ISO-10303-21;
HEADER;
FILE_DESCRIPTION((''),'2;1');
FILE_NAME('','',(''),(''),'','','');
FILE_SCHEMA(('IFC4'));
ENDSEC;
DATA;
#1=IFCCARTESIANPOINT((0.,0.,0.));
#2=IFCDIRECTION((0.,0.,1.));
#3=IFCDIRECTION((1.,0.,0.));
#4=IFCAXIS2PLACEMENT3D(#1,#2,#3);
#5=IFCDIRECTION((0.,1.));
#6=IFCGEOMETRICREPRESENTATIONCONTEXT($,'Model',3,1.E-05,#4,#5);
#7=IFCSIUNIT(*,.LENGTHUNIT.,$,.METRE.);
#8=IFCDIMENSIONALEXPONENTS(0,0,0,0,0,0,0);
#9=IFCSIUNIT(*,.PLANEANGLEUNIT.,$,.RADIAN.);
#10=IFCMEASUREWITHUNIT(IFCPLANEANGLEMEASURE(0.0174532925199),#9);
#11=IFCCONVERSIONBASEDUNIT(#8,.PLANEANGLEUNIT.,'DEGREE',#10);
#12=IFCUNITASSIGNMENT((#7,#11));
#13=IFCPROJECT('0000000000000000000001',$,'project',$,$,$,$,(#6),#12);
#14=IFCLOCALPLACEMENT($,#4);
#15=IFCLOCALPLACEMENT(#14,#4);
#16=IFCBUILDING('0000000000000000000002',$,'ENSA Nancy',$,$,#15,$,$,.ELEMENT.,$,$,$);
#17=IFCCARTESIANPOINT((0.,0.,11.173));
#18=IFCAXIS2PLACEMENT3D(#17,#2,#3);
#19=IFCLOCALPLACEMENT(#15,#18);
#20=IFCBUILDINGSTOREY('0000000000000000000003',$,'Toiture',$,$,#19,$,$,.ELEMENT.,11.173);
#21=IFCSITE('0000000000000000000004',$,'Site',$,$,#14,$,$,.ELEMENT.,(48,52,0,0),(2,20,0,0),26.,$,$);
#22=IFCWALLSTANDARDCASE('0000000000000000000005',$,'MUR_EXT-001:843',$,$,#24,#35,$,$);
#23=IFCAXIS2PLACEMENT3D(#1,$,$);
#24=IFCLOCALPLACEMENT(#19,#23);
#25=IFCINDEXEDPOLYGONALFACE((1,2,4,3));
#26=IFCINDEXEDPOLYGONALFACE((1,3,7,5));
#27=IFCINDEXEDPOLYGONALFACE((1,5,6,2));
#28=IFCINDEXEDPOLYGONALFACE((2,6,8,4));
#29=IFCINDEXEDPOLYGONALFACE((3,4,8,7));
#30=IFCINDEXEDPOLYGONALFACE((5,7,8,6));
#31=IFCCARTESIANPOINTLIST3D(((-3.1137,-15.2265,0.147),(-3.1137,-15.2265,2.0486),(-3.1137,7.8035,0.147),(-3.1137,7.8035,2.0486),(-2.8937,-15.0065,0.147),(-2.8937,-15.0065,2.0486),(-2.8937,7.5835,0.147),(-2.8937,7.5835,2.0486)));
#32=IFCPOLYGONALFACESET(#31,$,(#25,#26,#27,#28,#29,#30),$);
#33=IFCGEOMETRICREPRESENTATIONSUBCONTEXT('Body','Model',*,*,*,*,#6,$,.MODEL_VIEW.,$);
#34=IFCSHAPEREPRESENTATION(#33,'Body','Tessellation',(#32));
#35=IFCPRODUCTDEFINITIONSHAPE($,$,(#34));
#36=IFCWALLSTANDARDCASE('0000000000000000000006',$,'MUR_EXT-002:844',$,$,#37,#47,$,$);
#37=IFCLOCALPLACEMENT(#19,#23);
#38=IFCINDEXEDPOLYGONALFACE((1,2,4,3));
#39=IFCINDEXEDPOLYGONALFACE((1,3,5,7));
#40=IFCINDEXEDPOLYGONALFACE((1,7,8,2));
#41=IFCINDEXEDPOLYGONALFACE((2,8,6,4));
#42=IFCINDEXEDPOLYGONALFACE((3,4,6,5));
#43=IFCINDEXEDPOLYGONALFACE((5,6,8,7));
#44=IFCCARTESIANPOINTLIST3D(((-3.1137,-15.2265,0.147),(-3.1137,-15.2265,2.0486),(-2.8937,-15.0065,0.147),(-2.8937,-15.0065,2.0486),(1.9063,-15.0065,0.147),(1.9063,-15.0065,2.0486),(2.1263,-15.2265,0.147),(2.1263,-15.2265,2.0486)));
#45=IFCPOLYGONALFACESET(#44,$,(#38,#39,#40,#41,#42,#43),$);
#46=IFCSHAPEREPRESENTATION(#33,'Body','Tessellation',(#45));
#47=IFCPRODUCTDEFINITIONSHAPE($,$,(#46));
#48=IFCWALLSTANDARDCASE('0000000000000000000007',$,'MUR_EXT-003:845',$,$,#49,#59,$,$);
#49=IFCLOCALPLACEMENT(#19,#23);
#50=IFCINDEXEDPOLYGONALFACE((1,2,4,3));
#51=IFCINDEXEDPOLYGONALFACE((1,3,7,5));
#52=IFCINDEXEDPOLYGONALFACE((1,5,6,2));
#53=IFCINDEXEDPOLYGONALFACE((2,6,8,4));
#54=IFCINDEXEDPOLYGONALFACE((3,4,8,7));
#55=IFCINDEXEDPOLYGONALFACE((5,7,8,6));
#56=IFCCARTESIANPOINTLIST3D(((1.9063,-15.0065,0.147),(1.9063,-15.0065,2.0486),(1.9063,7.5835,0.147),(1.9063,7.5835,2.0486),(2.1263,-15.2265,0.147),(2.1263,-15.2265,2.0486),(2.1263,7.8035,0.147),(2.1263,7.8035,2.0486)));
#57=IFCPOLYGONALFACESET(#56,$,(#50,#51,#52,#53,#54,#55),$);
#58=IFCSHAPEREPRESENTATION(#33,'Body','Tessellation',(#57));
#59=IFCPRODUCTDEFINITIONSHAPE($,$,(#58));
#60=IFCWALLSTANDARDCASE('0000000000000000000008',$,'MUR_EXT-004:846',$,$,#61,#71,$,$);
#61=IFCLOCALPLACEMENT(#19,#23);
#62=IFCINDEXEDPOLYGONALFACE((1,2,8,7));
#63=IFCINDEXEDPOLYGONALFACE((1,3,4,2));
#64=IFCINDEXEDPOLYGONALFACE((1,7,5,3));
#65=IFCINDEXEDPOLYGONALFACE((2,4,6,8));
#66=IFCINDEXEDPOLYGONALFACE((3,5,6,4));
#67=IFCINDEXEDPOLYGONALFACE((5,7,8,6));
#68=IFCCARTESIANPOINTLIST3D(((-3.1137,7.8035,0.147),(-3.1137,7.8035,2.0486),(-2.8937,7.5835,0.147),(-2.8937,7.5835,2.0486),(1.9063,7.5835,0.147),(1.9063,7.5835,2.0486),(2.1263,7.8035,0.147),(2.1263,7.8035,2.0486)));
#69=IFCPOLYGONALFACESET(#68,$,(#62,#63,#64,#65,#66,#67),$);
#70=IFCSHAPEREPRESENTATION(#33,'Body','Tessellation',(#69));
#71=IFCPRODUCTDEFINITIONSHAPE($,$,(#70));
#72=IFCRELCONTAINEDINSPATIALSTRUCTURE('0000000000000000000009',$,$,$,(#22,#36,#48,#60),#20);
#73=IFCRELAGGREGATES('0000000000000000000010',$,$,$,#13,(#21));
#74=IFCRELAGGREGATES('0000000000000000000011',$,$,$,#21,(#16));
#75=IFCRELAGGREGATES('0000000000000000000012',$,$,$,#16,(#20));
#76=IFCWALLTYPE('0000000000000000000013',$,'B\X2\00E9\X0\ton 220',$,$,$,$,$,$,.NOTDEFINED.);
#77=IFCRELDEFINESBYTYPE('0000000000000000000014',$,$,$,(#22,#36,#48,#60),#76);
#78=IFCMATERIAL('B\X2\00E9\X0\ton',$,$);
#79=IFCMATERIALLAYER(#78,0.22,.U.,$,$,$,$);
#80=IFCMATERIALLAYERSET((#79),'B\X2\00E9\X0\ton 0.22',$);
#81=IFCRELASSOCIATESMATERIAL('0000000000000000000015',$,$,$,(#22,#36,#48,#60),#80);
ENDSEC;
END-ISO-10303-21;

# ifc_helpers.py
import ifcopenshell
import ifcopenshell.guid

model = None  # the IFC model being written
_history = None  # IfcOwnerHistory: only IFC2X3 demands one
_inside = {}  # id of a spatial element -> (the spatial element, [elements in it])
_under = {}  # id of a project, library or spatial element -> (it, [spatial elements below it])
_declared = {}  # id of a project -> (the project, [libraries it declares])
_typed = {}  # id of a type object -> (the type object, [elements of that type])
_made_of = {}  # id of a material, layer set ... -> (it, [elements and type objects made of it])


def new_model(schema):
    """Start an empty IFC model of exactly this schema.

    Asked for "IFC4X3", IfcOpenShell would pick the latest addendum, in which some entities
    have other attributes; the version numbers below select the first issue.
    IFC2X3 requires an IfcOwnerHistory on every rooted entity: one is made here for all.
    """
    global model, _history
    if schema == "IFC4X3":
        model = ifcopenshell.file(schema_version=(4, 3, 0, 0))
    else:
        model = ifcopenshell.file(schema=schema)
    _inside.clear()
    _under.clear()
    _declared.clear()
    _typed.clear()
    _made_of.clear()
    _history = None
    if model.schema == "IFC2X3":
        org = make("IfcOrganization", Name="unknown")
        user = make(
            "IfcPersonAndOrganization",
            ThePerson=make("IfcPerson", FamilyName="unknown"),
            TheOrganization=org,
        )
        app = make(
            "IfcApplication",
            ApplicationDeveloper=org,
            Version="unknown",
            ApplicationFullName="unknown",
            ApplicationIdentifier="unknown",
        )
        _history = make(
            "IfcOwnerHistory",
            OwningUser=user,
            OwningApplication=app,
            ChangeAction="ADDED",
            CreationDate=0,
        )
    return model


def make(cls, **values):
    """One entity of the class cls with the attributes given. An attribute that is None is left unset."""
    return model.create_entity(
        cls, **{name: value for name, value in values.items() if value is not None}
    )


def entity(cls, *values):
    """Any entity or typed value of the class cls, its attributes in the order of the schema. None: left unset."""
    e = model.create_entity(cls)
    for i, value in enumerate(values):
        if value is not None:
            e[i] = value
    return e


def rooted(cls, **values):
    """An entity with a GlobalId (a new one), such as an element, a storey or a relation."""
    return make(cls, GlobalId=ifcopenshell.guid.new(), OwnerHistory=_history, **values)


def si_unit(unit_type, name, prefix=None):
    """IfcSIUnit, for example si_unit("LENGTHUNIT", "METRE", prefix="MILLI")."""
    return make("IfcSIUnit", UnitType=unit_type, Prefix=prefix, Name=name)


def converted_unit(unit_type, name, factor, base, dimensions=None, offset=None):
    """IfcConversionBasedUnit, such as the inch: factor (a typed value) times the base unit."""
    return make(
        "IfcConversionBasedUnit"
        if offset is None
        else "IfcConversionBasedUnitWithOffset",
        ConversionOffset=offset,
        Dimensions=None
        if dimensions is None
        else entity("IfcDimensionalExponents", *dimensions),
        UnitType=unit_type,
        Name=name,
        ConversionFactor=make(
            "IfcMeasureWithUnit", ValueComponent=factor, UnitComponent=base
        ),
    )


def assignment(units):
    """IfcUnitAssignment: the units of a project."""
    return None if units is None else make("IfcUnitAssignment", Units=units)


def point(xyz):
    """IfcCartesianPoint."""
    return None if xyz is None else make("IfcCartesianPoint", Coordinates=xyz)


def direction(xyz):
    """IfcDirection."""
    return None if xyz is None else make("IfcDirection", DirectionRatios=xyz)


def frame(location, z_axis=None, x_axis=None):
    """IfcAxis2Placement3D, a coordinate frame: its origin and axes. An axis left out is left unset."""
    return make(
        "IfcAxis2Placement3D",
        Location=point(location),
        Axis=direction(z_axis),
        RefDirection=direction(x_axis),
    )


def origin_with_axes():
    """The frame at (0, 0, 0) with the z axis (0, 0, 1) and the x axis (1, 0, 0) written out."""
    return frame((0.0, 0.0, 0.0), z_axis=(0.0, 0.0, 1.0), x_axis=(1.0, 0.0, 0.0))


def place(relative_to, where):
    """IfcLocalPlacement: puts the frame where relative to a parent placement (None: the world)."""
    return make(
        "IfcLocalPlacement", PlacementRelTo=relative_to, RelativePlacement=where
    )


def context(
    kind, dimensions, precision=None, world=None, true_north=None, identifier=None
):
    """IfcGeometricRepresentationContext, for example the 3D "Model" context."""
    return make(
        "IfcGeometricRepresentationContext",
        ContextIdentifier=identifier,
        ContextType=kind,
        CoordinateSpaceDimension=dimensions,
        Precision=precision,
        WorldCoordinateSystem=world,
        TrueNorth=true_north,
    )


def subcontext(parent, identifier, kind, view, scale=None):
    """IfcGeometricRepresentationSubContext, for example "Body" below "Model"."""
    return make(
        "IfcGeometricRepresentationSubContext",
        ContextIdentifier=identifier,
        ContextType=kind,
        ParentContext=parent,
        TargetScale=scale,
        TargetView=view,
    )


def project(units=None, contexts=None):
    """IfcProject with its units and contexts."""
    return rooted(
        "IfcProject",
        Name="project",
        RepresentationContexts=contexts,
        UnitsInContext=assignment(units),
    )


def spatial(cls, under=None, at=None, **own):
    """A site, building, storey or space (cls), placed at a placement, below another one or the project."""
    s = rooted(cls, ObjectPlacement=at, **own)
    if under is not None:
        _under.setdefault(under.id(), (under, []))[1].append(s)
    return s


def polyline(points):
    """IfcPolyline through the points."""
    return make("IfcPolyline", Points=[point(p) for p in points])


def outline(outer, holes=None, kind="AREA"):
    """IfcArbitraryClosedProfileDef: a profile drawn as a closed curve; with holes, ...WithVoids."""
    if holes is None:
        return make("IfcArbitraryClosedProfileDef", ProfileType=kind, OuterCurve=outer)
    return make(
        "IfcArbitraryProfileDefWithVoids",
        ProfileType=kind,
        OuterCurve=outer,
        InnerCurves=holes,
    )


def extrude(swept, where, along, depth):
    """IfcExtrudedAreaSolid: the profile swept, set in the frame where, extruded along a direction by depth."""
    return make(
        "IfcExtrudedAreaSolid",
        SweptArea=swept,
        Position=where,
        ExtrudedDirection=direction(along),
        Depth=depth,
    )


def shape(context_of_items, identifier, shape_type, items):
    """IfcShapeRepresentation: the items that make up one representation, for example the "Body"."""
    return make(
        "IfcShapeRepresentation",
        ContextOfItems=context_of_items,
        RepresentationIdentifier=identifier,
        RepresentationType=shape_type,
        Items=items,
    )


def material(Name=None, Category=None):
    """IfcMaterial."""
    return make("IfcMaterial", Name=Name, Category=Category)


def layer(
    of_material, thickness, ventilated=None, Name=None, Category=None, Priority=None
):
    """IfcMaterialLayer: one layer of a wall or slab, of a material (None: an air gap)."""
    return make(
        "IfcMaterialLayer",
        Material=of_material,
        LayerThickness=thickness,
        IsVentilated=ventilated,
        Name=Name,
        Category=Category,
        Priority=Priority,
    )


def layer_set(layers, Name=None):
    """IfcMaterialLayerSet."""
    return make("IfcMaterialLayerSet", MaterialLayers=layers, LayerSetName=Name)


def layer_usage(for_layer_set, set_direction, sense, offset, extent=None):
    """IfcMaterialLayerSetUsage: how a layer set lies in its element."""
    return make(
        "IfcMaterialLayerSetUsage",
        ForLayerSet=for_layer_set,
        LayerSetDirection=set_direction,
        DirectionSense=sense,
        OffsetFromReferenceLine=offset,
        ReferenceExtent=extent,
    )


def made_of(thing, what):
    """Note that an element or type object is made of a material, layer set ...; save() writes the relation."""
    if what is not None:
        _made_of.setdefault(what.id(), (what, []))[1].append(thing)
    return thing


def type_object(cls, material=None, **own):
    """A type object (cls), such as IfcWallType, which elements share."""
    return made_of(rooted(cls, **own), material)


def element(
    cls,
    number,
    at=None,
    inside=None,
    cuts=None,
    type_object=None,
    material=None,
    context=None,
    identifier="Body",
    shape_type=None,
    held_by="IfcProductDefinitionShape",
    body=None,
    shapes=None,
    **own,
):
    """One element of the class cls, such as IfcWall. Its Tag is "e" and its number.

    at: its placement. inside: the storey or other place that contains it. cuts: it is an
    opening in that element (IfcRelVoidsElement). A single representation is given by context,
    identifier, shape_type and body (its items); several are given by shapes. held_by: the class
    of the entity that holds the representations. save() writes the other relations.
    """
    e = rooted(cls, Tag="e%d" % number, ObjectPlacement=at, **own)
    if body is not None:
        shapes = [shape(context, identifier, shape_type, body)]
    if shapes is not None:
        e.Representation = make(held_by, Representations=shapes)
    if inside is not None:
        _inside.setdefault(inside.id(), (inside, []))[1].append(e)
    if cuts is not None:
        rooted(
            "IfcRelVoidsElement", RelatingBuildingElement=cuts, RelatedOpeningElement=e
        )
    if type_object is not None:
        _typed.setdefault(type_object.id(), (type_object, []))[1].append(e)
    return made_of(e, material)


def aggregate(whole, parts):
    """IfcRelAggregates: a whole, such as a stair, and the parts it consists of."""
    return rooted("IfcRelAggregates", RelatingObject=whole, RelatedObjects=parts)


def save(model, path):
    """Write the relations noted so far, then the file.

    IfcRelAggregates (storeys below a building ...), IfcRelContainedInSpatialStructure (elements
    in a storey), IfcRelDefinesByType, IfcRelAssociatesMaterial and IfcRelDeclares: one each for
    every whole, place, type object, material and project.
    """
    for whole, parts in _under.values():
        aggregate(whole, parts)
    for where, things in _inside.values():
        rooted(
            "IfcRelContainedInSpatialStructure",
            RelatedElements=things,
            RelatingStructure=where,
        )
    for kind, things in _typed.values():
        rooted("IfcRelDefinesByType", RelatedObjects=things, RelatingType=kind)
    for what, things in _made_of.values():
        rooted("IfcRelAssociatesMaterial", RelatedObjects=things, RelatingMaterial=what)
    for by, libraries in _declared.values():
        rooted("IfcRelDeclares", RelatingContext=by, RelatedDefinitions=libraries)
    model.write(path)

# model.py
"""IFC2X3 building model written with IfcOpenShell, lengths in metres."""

from ifc_helpers import new_model, entity, si_unit, converted_unit, direction, frame, origin_with_axes, place, context, subcontext, project, spatial, polyline, outline, extrude, material, layer, layer_set, layer_usage, type_object, element, save


model = new_model("IFC2X3")

# Units and contexts
model_context = context("Model", 3, precision=1e-05, world=origin_with_axes(), true_north=direction((0.0, 1.0)))
body_context = subcontext(model_context, "Body", "Model", "MODEL_VIEW")
ifc_project = project(units=[si_unit("LENGTHUNIT", "METRE"), converted_unit("PLANEANGLEUNIT", "DEGREE", entity("IfcPlaneAngleMeasure", 0.0174532925199), si_unit("PLANEANGLEUNIT", "RADIAN"), dimensions=[0, 0, 0, 0, 0, 0, 0])], contexts=[model_context])

# Site, building, storey
site_placement = place(None, origin_with_axes())
site = spatial("IfcSite", under=ifc_project, at=site_placement, Name="Site", CompositionType="ELEMENT", RefLatitude=(48, 52, 0, 0), RefLongitude=(2, 20, 0, 0), RefElevation=26.0)
building_placement = place(site_placement, origin_with_axes())
building = spatial("IfcBuilding", under=site, at=building_placement, Name="ENSA Nancy", CompositionType="ELEMENT")
storey_placement = place(building_placement, frame((0.0, 0.0, 11.173), z_axis=(0.0, 0.0, 1.0), x_axis=(1.0, 0.0, 0.0)))
storey = spatial("IfcBuildingStorey", under=building, at=storey_placement, Name="Toiture", CompositionType="ELEMENT", Elevation=11.173)

# Walls
ifc_material = material(Name="Béton")
ifc_layer = layer(ifc_material, 0.22, ventilated="UNKNOWN")
ifc_layer_set = layer_set([ifc_layer], Name="Béton 0.22")
ifc_layer_usage_1 = layer_usage(ifc_layer_set, "AXIS2", "POSITIVE", 0.0)
wall_type = type_object("IfcWallType", Name="Béton 220", PredefinedType="NOTDEFINED")
wall_1_placement = place(storey_placement, frame((-3.1137, 7.8035, 0.147), z_axis=(0.0, 0.0, 1.0), x_axis=(0.0, -1.0, 0.0)))
element("IfcWallStandardCase", 1, at=wall_1_placement, inside=storey, type_object=wall_type, material=ifc_layer_usage_1, Name="MUR_EXT-001:843", context=body_context, shape_type="SweptSolid", body=[
    extrude(outline(polyline([(0.0, 0.0), (23.03, 0.0), (22.81, 0.22), (0.22, 0.22), (0.0, 0.0)])), origin_with_axes(), (0.0, 0.0, 1.0), 1.9016),
])
ifc_layer_usage_2 = layer_usage(ifc_layer_set, "AXIS2", "POSITIVE", 0.0)
wall_2_placement = place(storey_placement, frame((-3.1137, -15.2265, 0.147), z_axis=(0.0, 0.0, 1.0), x_axis=(1.0, 0.0, 0.0)))
element("IfcWallStandardCase", 2, at=wall_2_placement, inside=storey, type_object=wall_type, material=ifc_layer_usage_2, Name="MUR_EXT-002:844", context=body_context, shape_type="SweptSolid", body=[
    extrude(outline(polyline([(0.0, 0.0), (5.24, 0.0), (5.02, 0.22), (0.22, 0.22), (0.0, 0.0)])), origin_with_axes(), (0.0, 0.0, 1.0), 1.9016),
])
ifc_layer_usage_3 = layer_usage(ifc_layer_set, "AXIS2", "POSITIVE", 0.0)
wall_3_placement = place(storey_placement, frame((2.1263, -15.2265, 0.147), z_axis=(0.0, 0.0, 1.0), x_axis=(0.0, 1.0, 0.0)))
element("IfcWallStandardCase", 3, at=wall_3_placement, inside=storey, type_object=wall_type, material=ifc_layer_usage_3, Name="MUR_EXT-003:845", context=body_context, shape_type="SweptSolid", body=[
    extrude(outline(polyline([(0.0, 0.0), (23.03, 0.0), (22.81, 0.22), (0.22, 0.22), (0.0, 0.0)])), origin_with_axes(), (0.0, 0.0, 1.0), 1.9016),
])
ifc_layer_usage_4 = layer_usage(ifc_layer_set, "AXIS2", "POSITIVE", 0.0)
wall_4_placement = place(storey_placement, frame((2.1263, 7.8035, 0.147), z_axis=(0.0, 0.0, 1.0), x_axis=(-1.0, 0.0, 0.0)))
element("IfcWallStandardCase", 4, at=wall_4_placement, inside=storey, type_object=wall_type, material=ifc_layer_usage_4, Name="MUR_EXT-004:846", context=body_context, shape_type="SweptSolid", body=[
    extrude(outline(polyline([(0.0, 0.0), (5.24, 0.0), (5.02, 0.22), (0.22, 0.22), (0.0, 0.0)])), origin_with_axes(), (0.0, 0.0, 1.0), 1.9016),
])

save(model, "model.ifc")
